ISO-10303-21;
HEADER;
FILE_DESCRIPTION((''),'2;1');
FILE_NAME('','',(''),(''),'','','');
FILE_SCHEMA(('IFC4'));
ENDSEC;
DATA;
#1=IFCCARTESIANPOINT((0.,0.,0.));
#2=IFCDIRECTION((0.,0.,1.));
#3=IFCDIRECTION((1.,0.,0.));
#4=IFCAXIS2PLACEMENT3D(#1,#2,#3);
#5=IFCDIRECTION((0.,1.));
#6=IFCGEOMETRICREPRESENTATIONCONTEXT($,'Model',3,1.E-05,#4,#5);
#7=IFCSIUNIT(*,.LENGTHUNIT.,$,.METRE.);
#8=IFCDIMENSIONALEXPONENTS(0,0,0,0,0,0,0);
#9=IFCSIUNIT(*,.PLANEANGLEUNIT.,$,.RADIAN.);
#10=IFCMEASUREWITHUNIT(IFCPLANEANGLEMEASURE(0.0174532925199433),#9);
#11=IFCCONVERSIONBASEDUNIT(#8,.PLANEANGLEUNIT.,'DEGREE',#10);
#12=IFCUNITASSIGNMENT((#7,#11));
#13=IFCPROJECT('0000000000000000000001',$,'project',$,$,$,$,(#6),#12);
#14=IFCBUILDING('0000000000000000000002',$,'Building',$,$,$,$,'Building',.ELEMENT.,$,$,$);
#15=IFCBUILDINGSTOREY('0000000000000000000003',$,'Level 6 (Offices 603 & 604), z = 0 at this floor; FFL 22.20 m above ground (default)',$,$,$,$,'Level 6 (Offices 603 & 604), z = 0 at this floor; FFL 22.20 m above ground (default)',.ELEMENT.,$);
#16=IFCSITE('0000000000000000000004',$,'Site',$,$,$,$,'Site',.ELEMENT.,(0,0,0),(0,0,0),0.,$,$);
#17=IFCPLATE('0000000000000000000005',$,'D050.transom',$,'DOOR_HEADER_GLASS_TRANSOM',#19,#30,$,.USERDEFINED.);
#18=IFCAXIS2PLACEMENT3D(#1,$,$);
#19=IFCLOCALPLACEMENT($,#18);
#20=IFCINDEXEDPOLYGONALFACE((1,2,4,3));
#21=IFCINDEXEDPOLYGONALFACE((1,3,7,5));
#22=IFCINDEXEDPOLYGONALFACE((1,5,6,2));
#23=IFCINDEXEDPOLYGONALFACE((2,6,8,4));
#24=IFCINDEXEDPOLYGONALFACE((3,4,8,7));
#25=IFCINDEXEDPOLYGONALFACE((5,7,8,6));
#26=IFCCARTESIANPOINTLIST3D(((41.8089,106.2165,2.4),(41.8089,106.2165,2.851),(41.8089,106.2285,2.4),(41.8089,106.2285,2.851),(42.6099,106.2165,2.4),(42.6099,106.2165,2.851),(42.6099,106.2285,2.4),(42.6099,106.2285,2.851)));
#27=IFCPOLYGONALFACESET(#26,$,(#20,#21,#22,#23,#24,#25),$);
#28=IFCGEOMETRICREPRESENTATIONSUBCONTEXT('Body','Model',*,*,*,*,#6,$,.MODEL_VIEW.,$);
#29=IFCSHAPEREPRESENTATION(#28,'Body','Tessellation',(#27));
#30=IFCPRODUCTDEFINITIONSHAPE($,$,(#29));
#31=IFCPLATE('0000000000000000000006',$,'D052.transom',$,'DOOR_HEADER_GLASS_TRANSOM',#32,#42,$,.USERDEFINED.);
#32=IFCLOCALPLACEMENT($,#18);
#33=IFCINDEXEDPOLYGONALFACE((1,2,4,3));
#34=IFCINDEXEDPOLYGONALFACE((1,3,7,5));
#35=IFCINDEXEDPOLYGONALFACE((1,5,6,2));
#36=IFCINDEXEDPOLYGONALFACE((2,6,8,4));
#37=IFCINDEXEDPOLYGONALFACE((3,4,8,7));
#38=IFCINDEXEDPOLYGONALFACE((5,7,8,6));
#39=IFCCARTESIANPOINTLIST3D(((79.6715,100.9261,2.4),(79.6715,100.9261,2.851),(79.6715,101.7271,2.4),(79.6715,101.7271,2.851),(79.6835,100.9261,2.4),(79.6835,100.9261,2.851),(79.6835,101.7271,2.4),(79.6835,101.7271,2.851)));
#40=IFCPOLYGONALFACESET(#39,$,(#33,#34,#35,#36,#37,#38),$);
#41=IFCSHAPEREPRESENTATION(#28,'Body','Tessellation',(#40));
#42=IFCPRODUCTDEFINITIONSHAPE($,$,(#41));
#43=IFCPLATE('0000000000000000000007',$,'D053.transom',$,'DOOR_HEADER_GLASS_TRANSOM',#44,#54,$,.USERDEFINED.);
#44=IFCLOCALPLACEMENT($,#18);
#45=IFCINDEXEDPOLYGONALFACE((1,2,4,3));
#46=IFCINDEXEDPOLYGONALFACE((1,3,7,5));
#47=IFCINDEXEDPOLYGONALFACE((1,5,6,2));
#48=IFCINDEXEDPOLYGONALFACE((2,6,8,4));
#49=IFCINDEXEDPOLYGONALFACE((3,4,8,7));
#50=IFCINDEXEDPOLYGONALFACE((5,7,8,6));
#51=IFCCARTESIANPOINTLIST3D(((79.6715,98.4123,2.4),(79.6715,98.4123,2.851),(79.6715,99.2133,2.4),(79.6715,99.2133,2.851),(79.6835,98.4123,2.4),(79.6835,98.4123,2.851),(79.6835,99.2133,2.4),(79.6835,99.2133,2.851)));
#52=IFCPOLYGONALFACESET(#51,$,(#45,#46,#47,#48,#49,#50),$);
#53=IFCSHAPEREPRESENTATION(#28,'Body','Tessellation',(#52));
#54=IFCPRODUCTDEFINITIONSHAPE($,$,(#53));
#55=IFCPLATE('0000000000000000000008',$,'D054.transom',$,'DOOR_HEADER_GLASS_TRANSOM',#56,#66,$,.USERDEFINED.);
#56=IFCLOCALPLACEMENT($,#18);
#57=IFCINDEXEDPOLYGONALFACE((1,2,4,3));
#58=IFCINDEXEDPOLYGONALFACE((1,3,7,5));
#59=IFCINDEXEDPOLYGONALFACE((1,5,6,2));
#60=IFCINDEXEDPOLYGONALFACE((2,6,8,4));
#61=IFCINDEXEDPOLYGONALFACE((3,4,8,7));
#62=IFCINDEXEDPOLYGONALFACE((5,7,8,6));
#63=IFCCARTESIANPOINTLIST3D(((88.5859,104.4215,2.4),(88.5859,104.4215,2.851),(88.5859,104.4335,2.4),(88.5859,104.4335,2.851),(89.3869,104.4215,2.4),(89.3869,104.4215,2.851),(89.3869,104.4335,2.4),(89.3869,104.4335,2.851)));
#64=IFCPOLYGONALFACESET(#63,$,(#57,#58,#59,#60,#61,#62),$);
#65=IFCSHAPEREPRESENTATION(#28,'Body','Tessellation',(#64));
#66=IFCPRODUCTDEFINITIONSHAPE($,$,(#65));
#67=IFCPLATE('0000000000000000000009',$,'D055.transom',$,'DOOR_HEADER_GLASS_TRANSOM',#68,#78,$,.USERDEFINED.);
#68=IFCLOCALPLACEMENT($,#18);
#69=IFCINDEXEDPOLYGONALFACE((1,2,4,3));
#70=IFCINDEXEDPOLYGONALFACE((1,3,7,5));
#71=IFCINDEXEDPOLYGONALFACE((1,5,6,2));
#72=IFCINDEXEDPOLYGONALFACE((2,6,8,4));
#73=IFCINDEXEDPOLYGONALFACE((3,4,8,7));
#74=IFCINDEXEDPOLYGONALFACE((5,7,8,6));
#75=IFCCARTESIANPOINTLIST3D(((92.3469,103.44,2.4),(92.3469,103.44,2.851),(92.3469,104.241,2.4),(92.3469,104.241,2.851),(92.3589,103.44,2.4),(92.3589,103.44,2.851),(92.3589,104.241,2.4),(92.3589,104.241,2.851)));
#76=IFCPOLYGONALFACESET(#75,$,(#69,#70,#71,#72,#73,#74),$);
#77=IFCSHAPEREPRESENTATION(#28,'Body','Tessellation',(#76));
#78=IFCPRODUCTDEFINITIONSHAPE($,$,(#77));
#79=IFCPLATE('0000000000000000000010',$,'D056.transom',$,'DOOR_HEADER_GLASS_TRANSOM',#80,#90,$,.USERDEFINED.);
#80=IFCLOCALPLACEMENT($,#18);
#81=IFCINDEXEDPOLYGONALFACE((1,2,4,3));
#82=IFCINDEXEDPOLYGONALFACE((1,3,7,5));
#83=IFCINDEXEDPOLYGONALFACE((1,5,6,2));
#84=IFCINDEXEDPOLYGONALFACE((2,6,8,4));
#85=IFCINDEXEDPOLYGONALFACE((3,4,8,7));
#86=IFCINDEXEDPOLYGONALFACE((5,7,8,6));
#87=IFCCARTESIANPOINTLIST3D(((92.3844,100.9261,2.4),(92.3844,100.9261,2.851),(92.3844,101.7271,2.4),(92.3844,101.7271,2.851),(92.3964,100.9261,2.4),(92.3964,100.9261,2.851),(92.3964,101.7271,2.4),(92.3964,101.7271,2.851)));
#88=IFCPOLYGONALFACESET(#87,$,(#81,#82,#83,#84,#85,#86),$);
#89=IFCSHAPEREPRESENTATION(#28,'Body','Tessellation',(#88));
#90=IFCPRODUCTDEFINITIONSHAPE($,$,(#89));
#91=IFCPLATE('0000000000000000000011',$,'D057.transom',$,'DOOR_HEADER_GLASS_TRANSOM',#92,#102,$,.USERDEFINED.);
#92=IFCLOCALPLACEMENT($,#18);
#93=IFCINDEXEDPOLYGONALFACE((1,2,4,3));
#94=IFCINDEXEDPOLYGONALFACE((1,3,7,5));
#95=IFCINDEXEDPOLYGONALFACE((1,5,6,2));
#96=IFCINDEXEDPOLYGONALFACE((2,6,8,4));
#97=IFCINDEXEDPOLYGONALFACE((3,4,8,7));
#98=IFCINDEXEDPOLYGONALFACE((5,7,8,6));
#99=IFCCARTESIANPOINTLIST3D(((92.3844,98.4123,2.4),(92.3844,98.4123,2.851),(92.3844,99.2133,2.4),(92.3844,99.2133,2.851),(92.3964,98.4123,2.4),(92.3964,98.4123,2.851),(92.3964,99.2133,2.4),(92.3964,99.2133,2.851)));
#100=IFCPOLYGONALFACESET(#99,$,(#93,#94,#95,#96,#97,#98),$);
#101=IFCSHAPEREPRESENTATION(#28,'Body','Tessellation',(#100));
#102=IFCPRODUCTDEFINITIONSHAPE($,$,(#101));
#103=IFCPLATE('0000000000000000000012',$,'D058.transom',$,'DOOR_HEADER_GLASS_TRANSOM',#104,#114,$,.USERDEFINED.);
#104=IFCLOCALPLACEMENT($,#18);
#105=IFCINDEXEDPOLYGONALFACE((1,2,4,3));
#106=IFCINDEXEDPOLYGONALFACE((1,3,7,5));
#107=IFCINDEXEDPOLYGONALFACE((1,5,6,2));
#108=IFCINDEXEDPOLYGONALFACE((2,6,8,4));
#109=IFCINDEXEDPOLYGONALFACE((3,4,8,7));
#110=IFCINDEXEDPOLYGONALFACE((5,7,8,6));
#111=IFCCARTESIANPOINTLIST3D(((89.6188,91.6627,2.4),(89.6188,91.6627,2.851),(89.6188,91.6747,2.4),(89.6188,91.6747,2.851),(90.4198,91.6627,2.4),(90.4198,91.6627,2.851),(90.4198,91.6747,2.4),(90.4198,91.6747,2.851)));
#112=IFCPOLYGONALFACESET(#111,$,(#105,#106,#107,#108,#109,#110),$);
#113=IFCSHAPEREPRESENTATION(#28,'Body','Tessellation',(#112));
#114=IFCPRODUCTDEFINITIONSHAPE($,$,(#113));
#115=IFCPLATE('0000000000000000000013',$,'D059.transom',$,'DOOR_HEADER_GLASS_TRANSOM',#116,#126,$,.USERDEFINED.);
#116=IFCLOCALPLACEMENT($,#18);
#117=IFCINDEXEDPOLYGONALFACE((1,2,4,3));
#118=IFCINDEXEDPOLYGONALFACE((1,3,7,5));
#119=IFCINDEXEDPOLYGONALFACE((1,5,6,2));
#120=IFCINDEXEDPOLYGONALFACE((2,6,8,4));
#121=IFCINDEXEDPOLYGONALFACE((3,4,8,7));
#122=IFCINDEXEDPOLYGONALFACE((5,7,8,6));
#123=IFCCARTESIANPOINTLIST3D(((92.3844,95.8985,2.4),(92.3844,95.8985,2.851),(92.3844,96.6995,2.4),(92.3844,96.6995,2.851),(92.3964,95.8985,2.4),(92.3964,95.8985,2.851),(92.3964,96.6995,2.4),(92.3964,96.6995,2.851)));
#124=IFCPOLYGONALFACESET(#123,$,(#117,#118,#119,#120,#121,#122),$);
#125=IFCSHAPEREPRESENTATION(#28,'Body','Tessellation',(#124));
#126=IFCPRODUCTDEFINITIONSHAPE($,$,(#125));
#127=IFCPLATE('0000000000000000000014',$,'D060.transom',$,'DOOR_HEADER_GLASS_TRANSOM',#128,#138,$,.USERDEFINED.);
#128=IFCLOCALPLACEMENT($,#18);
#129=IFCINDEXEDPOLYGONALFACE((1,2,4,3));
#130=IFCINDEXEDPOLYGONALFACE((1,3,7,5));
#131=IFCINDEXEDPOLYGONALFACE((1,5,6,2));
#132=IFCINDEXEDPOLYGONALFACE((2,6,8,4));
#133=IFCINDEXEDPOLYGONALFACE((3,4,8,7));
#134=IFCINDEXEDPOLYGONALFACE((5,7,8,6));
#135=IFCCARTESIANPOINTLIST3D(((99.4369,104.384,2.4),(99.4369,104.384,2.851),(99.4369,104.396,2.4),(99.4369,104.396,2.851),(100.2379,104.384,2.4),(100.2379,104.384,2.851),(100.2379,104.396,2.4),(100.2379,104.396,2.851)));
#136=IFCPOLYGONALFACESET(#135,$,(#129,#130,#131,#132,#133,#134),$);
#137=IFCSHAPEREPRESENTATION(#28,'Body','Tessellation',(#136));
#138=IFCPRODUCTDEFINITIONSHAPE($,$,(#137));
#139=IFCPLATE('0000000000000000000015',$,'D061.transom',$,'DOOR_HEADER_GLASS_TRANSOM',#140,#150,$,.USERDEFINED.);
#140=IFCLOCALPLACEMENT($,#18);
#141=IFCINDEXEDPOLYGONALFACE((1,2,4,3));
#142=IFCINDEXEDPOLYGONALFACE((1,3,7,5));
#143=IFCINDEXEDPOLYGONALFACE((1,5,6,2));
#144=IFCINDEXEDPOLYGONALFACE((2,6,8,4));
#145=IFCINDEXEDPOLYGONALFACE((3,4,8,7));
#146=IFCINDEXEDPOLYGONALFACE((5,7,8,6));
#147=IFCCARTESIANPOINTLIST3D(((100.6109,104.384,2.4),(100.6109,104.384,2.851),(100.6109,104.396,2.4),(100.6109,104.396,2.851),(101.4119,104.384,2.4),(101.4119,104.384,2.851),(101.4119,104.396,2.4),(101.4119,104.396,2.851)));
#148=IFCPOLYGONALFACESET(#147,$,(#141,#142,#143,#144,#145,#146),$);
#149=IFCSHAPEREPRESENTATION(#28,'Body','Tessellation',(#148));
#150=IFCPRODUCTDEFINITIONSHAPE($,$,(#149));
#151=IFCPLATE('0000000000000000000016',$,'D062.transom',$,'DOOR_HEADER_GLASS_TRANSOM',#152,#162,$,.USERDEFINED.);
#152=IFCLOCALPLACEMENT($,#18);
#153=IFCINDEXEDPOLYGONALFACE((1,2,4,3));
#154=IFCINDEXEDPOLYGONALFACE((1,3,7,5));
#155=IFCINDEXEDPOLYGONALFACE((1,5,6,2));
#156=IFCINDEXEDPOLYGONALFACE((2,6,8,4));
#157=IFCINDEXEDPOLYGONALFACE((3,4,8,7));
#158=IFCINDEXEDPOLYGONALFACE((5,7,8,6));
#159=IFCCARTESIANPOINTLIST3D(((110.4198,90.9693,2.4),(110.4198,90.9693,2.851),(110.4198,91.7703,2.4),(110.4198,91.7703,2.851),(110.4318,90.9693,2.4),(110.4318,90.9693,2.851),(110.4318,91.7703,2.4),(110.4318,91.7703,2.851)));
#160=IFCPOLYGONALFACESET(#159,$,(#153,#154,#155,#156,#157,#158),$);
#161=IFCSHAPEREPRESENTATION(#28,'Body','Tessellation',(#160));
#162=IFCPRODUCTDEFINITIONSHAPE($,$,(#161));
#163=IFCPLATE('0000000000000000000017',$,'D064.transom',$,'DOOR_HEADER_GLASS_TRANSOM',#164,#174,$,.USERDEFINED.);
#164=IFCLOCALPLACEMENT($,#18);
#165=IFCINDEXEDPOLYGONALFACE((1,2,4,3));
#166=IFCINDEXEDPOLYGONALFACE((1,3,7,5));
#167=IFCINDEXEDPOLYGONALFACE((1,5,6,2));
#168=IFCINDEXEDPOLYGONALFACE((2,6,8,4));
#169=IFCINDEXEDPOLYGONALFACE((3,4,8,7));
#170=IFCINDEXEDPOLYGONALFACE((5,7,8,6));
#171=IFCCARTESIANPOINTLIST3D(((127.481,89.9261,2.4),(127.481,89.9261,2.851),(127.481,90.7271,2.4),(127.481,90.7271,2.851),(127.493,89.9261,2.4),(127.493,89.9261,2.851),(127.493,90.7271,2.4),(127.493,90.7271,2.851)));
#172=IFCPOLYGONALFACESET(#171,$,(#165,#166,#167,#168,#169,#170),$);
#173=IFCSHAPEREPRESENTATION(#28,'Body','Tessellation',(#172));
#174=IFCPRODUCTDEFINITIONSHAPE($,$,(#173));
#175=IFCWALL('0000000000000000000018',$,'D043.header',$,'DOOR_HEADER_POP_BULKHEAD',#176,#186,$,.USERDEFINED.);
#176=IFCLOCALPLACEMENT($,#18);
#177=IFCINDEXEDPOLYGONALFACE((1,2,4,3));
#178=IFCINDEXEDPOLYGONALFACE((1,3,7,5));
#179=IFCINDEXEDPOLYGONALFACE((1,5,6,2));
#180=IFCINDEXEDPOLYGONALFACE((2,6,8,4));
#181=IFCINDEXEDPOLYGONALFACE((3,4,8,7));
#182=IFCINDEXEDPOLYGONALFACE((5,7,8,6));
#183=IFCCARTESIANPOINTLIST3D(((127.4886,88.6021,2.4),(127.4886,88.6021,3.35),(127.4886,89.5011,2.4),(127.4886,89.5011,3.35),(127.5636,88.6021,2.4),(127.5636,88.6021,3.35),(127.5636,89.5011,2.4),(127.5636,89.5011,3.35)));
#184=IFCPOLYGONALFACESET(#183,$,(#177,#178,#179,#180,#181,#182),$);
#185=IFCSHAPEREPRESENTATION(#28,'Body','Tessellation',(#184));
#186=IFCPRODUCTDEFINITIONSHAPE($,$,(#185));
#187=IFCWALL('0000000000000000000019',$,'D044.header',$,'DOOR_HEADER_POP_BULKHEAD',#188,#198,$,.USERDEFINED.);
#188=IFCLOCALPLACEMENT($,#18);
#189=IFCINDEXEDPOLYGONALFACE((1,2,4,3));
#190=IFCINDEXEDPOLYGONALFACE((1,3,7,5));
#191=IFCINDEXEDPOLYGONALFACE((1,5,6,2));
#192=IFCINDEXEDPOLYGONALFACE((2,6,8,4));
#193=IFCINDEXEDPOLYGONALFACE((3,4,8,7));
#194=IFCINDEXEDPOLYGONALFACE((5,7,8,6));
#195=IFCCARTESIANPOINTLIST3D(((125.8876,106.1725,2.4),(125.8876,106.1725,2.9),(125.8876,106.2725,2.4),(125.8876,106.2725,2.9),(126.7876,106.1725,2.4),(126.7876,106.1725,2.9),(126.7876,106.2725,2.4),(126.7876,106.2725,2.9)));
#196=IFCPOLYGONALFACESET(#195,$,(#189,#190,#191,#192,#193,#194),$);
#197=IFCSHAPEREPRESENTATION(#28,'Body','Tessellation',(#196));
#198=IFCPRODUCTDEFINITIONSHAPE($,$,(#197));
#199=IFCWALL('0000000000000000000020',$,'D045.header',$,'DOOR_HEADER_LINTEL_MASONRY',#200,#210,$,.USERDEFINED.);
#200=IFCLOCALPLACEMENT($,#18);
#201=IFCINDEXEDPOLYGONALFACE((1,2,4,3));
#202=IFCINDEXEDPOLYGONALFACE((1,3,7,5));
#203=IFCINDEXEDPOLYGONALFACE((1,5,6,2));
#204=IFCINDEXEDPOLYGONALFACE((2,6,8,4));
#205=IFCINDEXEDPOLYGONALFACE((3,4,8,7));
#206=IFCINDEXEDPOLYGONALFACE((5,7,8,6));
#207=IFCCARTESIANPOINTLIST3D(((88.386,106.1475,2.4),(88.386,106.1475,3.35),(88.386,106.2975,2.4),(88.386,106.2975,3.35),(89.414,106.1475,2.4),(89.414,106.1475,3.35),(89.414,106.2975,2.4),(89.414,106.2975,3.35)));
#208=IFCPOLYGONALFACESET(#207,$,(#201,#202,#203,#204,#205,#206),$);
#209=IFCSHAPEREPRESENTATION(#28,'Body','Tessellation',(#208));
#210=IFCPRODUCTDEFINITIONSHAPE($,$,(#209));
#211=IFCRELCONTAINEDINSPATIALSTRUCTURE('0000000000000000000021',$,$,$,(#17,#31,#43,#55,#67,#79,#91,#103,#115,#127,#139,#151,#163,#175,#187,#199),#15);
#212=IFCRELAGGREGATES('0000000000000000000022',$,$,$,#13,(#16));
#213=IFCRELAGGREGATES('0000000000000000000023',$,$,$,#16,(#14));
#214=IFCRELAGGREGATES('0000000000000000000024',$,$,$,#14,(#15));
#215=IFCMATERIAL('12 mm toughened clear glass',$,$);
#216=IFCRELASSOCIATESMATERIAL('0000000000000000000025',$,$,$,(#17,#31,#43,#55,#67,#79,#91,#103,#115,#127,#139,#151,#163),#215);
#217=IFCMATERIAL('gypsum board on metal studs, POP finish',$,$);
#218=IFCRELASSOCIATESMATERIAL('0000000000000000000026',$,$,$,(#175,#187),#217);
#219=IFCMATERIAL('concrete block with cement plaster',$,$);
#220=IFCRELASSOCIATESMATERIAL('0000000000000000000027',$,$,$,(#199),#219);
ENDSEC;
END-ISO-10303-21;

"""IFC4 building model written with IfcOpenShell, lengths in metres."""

from ifc_helpers import new_model, entity, si_unit, converted_unit, direction, frame, frame_2d, origin_with_axes, origin_2d_with_axis, place, context, subcontext, project, spatial, rectangle, extrude, material, element, save


model = new_model("IFC4")

# Units and contexts
model_context = context("Model", 3, precision=1e-05, world=origin_with_axes(), true_north=direction((0.0, 1.0)))
body_context = subcontext(model_context, "Body", "Model", "MODEL_VIEW")
ifc_project = project(units=[si_unit("LENGTHUNIT", "METRE"), converted_unit("PLANEANGLEUNIT", "DEGREE", entity("IfcPlaneAngleMeasure", 0.0174532925199433), si_unit("PLANEANGLEUNIT", "RADIAN"), dimensions=[0, 0, 0, 0, 0, 0, 0])], contexts=[model_context])

# Site, building, storey
site = spatial("IfcSite", under=ifc_project, Name="Site", LongName="Site", CompositionType="ELEMENT", RefLatitude=(0, 0, 0), RefLongitude=(0, 0, 0), RefElevation=0.0)
building = spatial("IfcBuilding", under=site, Name="Building", LongName="Building", CompositionType="ELEMENT")
storey = spatial("IfcBuildingStorey", under=building, Name="Level 6 (Offices 603 & 604), z = 0 at this floor; FFL 22.20 m above ground (default)", LongName="Level 6 (Offices 603 & 604), z = 0 at this floor; FFL 22.20 m above ground (default)", CompositionType="ELEMENT")

# Plates
ifc_material_1 = material(Name="12 mm toughened clear glass")
placement = place(None, origin_with_axes())
element("IfcPlate", 1, at=placement, inside=storey, material=ifc_material_1, Name="D050.transom", ObjectType="DOOR_HEADER_GLASS_TRANSOM", PredefinedType="USERDEFINED", context=body_context, shape_type="SweptSolid", body=[
    extrude(rectangle(XDim=0.801, YDim=0.012, at=frame_2d((0.0, 0.0), x_axis=(1.0, 0.0))), frame((42.2094, 106.2225, 2.4), z_axis=(0.0, 0.0, 1.0), x_axis=(1.0, 0.0, 0.0)), (0.0, 0.0, 1.0), 0.451),
])
element("IfcPlate", 2, at=placement, inside=storey, material=ifc_material_1, Name="D052.transom", ObjectType="DOOR_HEADER_GLASS_TRANSOM", PredefinedType="USERDEFINED", context=body_context, shape_type="SweptSolid", body=[
    extrude(rectangle(XDim=0.801, YDim=0.012, at=frame_2d((0.0, 0.0), x_axis=(0.0, 1.0))), frame((79.6775, 101.3266, 2.4), z_axis=(0.0, 0.0, 1.0), x_axis=(1.0, 0.0, 0.0)), (0.0, 0.0, 1.0), 0.451),
])
element("IfcPlate", 3, at=placement, inside=storey, material=ifc_material_1, Name="D053.transom", ObjectType="DOOR_HEADER_GLASS_TRANSOM", PredefinedType="USERDEFINED", context=body_context, shape_type="SweptSolid", body=[
    extrude(rectangle(XDim=0.801, YDim=0.012, at=frame_2d((0.0, 0.0), x_axis=(0.0, 1.0))), frame((79.6775, 98.8128, 2.4), z_axis=(0.0, 0.0, 1.0), x_axis=(1.0, 0.0, 0.0)), (0.0, 0.0, 1.0), 0.451),
])
element("IfcPlate", 4, at=placement, inside=storey, material=ifc_material_1, Name="D054.transom", ObjectType="DOOR_HEADER_GLASS_TRANSOM", PredefinedType="USERDEFINED", context=body_context, shape_type="SweptSolid", body=[
    extrude(rectangle(XDim=0.801, YDim=0.012, at=origin_2d_with_axis()), frame((88.9864, 104.4275, 2.4), z_axis=(0.0, 0.0, 1.0), x_axis=(1.0, 0.0, 0.0)), (0.0, 0.0, 1.0), 0.451),
])
element("IfcPlate", 5, at=placement, inside=storey, material=ifc_material_1, Name="D055.transom", ObjectType="DOOR_HEADER_GLASS_TRANSOM", PredefinedType="USERDEFINED", context=body_context, shape_type="SweptSolid", body=[
    extrude(rectangle(XDim=0.801, YDim=0.012, at=frame_2d((0.0, 0.0), x_axis=(0.0, 1.0))), frame((92.3529, 103.8405, 2.4), z_axis=(0.0, 0.0, 1.0), x_axis=(1.0, 0.0, 0.0)), (0.0, 0.0, 1.0), 0.451),
])
element("IfcPlate", 6, at=placement, inside=storey, material=ifc_material_1, Name="D056.transom", ObjectType="DOOR_HEADER_GLASS_TRANSOM", PredefinedType="USERDEFINED", context=body_context, shape_type="SweptSolid", body=[
    extrude(rectangle(XDim=0.801, YDim=0.012, at=frame_2d((0.0, 0.0), x_axis=(0.0, 1.0))), frame((92.3904, 101.3266, 2.4), z_axis=(0.0, 0.0, 1.0), x_axis=(1.0, 0.0, 0.0)), (0.0, 0.0, 1.0), 0.451),
])
element("IfcPlate", 7, at=placement, inside=storey, material=ifc_material_1, Name="D057.transom", ObjectType="DOOR_HEADER_GLASS_TRANSOM", PredefinedType="USERDEFINED", context=body_context, shape_type="SweptSolid", body=[
    extrude(rectangle(XDim=0.801, YDim=0.012, at=frame_2d((0.0, 0.0), x_axis=(0.0, 1.0))), frame((92.3904, 98.8128, 2.4), z_axis=(0.0, 0.0, 1.0), x_axis=(1.0, 0.0, 0.0)), (0.0, 0.0, 1.0), 0.451),
])
element("IfcPlate", 8, at=placement, inside=storey, material=ifc_material_1, Name="D058.transom", ObjectType="DOOR_HEADER_GLASS_TRANSOM", PredefinedType="USERDEFINED", context=body_context, shape_type="SweptSolid", body=[
    extrude(rectangle(XDim=0.801, YDim=0.012, at=frame_2d((0.0, 0.0), x_axis=(1.0, 0.0))), frame((90.0192, 91.6687, 2.4), z_axis=(0.0, 0.0, 1.0), x_axis=(1.0, 0.0, 0.0)), (0.0, 0.0, 1.0), 0.451),
])
element("IfcPlate", 9, at=placement, inside=storey, material=ifc_material_1, Name="D059.transom", ObjectType="DOOR_HEADER_GLASS_TRANSOM", PredefinedType="USERDEFINED", context=body_context, shape_type="SweptSolid", body=[
    extrude(rectangle(XDim=0.801, YDim=0.012, at=frame_2d((0.0, 0.0), x_axis=(0.0, 1.0))), frame((92.3904, 96.299, 2.4), z_axis=(0.0, 0.0, 1.0), x_axis=(1.0, 0.0, 0.0)), (0.0, 0.0, 1.0), 0.451),
])
element("IfcPlate", 10, at=placement, inside=storey, material=ifc_material_1, Name="D060.transom", ObjectType="DOOR_HEADER_GLASS_TRANSOM", PredefinedType="USERDEFINED", context=body_context, shape_type="SweptSolid", body=[
    extrude(rectangle(XDim=0.801, YDim=0.012, at=origin_2d_with_axis()), frame((99.8374, 104.39, 2.4), z_axis=(0.0, 0.0, 1.0), x_axis=(1.0, 0.0, 0.0)), (0.0, 0.0, 1.0), 0.451),
])
element("IfcPlate", 11, at=placement, inside=storey, material=ifc_material_1, Name="D061.transom", ObjectType="DOOR_HEADER_GLASS_TRANSOM", PredefinedType="USERDEFINED", context=body_context, shape_type="SweptSolid", body=[
    extrude(rectangle(XDim=0.801, YDim=0.012, at=frame_2d((0.0, 0.0), x_axis=(1.0, 0.0))), frame((101.0114, 104.39, 2.4), z_axis=(0.0, 0.0, 1.0), x_axis=(1.0, 0.0, 0.0)), (0.0, 0.0, 1.0), 0.451),
])
element("IfcPlate", 12, at=placement, inside=storey, material=ifc_material_1, Name="D062.transom", ObjectType="DOOR_HEADER_GLASS_TRANSOM", PredefinedType="USERDEFINED", context=body_context, shape_type="SweptSolid", body=[
    extrude(rectangle(XDim=0.801, YDim=0.012, at=frame_2d((0.0, 0.0), x_axis=(0.0, 1.0))), frame((110.4258, 91.3698, 2.4), z_axis=(0.0, 0.0, 1.0), x_axis=(1.0, 0.0, 0.0)), (0.0, 0.0, 1.0), 0.451),
])
element("IfcPlate", 13, at=placement, inside=storey, material=ifc_material_1, Name="D064.transom", ObjectType="DOOR_HEADER_GLASS_TRANSOM", PredefinedType="USERDEFINED", context=body_context, shape_type="SweptSolid", body=[
    extrude(rectangle(XDim=0.801, YDim=0.012, at=frame_2d((0.0, 0.0), x_axis=(0.0, 1.0))), frame((127.487, 90.3266, 2.4), z_axis=(0.0, 0.0, 1.0), x_axis=(1.0, 0.0, 0.0)), (0.0, 0.0, 1.0), 0.451),
])

# Walls
ifc_material_2 = material(Name="gypsum board on metal studs, POP finish")
element("IfcWall", 14, at=placement, inside=storey, material=ifc_material_2, Name="D043.header", ObjectType="DOOR_HEADER_POP_BULKHEAD", PredefinedType="USERDEFINED", context=body_context, shape_type="SweptSolid", body=[
    extrude(rectangle(XDim=0.899, YDim=0.075, at=frame_2d((0.0, 0.0), x_axis=(0.0, 1.0))), frame((127.5261, 89.0516, 2.4), z_axis=(0.0, 0.0, 1.0), x_axis=(1.0, 0.0, 0.0)), (0.0, 0.0, 1.0), 0.95),
])
element("IfcWall", 15, at=placement, inside=storey, material=ifc_material_2, Name="D044.header", ObjectType="DOOR_HEADER_POP_BULKHEAD", PredefinedType="USERDEFINED", context=body_context, shape_type="SweptSolid", body=[
    extrude(rectangle(XDim=0.9, YDim=0.1, at=frame_2d((0.0, 0.0), x_axis=(1.0, 0.0))), frame((126.3376, 106.2225, 2.4), z_axis=(0.0, 0.0, 1.0), x_axis=(1.0, 0.0, 0.0)), (0.0, 0.0, 1.0), 0.5),
])
ifc_material_3 = material(Name="concrete block with cement plaster")
element("IfcWall", 16, at=placement, inside=storey, material=ifc_material_3, Name="D045.header", ObjectType="DOOR_HEADER_LINTEL_MASONRY", PredefinedType="USERDEFINED", context=body_context, shape_type="SweptSolid", body=[
    extrude(rectangle(XDim=1.028, YDim=0.15, at=frame_2d((0.0, 0.0), x_axis=(1.0, 0.0))), frame((88.9, 106.2225, 2.4), z_axis=(0.0, 0.0, 1.0), x_axis=(1.0, 0.0, 0.0)), (0.0, 0.0, 1.0), 0.95),
])

save(model, "model.ifc")
